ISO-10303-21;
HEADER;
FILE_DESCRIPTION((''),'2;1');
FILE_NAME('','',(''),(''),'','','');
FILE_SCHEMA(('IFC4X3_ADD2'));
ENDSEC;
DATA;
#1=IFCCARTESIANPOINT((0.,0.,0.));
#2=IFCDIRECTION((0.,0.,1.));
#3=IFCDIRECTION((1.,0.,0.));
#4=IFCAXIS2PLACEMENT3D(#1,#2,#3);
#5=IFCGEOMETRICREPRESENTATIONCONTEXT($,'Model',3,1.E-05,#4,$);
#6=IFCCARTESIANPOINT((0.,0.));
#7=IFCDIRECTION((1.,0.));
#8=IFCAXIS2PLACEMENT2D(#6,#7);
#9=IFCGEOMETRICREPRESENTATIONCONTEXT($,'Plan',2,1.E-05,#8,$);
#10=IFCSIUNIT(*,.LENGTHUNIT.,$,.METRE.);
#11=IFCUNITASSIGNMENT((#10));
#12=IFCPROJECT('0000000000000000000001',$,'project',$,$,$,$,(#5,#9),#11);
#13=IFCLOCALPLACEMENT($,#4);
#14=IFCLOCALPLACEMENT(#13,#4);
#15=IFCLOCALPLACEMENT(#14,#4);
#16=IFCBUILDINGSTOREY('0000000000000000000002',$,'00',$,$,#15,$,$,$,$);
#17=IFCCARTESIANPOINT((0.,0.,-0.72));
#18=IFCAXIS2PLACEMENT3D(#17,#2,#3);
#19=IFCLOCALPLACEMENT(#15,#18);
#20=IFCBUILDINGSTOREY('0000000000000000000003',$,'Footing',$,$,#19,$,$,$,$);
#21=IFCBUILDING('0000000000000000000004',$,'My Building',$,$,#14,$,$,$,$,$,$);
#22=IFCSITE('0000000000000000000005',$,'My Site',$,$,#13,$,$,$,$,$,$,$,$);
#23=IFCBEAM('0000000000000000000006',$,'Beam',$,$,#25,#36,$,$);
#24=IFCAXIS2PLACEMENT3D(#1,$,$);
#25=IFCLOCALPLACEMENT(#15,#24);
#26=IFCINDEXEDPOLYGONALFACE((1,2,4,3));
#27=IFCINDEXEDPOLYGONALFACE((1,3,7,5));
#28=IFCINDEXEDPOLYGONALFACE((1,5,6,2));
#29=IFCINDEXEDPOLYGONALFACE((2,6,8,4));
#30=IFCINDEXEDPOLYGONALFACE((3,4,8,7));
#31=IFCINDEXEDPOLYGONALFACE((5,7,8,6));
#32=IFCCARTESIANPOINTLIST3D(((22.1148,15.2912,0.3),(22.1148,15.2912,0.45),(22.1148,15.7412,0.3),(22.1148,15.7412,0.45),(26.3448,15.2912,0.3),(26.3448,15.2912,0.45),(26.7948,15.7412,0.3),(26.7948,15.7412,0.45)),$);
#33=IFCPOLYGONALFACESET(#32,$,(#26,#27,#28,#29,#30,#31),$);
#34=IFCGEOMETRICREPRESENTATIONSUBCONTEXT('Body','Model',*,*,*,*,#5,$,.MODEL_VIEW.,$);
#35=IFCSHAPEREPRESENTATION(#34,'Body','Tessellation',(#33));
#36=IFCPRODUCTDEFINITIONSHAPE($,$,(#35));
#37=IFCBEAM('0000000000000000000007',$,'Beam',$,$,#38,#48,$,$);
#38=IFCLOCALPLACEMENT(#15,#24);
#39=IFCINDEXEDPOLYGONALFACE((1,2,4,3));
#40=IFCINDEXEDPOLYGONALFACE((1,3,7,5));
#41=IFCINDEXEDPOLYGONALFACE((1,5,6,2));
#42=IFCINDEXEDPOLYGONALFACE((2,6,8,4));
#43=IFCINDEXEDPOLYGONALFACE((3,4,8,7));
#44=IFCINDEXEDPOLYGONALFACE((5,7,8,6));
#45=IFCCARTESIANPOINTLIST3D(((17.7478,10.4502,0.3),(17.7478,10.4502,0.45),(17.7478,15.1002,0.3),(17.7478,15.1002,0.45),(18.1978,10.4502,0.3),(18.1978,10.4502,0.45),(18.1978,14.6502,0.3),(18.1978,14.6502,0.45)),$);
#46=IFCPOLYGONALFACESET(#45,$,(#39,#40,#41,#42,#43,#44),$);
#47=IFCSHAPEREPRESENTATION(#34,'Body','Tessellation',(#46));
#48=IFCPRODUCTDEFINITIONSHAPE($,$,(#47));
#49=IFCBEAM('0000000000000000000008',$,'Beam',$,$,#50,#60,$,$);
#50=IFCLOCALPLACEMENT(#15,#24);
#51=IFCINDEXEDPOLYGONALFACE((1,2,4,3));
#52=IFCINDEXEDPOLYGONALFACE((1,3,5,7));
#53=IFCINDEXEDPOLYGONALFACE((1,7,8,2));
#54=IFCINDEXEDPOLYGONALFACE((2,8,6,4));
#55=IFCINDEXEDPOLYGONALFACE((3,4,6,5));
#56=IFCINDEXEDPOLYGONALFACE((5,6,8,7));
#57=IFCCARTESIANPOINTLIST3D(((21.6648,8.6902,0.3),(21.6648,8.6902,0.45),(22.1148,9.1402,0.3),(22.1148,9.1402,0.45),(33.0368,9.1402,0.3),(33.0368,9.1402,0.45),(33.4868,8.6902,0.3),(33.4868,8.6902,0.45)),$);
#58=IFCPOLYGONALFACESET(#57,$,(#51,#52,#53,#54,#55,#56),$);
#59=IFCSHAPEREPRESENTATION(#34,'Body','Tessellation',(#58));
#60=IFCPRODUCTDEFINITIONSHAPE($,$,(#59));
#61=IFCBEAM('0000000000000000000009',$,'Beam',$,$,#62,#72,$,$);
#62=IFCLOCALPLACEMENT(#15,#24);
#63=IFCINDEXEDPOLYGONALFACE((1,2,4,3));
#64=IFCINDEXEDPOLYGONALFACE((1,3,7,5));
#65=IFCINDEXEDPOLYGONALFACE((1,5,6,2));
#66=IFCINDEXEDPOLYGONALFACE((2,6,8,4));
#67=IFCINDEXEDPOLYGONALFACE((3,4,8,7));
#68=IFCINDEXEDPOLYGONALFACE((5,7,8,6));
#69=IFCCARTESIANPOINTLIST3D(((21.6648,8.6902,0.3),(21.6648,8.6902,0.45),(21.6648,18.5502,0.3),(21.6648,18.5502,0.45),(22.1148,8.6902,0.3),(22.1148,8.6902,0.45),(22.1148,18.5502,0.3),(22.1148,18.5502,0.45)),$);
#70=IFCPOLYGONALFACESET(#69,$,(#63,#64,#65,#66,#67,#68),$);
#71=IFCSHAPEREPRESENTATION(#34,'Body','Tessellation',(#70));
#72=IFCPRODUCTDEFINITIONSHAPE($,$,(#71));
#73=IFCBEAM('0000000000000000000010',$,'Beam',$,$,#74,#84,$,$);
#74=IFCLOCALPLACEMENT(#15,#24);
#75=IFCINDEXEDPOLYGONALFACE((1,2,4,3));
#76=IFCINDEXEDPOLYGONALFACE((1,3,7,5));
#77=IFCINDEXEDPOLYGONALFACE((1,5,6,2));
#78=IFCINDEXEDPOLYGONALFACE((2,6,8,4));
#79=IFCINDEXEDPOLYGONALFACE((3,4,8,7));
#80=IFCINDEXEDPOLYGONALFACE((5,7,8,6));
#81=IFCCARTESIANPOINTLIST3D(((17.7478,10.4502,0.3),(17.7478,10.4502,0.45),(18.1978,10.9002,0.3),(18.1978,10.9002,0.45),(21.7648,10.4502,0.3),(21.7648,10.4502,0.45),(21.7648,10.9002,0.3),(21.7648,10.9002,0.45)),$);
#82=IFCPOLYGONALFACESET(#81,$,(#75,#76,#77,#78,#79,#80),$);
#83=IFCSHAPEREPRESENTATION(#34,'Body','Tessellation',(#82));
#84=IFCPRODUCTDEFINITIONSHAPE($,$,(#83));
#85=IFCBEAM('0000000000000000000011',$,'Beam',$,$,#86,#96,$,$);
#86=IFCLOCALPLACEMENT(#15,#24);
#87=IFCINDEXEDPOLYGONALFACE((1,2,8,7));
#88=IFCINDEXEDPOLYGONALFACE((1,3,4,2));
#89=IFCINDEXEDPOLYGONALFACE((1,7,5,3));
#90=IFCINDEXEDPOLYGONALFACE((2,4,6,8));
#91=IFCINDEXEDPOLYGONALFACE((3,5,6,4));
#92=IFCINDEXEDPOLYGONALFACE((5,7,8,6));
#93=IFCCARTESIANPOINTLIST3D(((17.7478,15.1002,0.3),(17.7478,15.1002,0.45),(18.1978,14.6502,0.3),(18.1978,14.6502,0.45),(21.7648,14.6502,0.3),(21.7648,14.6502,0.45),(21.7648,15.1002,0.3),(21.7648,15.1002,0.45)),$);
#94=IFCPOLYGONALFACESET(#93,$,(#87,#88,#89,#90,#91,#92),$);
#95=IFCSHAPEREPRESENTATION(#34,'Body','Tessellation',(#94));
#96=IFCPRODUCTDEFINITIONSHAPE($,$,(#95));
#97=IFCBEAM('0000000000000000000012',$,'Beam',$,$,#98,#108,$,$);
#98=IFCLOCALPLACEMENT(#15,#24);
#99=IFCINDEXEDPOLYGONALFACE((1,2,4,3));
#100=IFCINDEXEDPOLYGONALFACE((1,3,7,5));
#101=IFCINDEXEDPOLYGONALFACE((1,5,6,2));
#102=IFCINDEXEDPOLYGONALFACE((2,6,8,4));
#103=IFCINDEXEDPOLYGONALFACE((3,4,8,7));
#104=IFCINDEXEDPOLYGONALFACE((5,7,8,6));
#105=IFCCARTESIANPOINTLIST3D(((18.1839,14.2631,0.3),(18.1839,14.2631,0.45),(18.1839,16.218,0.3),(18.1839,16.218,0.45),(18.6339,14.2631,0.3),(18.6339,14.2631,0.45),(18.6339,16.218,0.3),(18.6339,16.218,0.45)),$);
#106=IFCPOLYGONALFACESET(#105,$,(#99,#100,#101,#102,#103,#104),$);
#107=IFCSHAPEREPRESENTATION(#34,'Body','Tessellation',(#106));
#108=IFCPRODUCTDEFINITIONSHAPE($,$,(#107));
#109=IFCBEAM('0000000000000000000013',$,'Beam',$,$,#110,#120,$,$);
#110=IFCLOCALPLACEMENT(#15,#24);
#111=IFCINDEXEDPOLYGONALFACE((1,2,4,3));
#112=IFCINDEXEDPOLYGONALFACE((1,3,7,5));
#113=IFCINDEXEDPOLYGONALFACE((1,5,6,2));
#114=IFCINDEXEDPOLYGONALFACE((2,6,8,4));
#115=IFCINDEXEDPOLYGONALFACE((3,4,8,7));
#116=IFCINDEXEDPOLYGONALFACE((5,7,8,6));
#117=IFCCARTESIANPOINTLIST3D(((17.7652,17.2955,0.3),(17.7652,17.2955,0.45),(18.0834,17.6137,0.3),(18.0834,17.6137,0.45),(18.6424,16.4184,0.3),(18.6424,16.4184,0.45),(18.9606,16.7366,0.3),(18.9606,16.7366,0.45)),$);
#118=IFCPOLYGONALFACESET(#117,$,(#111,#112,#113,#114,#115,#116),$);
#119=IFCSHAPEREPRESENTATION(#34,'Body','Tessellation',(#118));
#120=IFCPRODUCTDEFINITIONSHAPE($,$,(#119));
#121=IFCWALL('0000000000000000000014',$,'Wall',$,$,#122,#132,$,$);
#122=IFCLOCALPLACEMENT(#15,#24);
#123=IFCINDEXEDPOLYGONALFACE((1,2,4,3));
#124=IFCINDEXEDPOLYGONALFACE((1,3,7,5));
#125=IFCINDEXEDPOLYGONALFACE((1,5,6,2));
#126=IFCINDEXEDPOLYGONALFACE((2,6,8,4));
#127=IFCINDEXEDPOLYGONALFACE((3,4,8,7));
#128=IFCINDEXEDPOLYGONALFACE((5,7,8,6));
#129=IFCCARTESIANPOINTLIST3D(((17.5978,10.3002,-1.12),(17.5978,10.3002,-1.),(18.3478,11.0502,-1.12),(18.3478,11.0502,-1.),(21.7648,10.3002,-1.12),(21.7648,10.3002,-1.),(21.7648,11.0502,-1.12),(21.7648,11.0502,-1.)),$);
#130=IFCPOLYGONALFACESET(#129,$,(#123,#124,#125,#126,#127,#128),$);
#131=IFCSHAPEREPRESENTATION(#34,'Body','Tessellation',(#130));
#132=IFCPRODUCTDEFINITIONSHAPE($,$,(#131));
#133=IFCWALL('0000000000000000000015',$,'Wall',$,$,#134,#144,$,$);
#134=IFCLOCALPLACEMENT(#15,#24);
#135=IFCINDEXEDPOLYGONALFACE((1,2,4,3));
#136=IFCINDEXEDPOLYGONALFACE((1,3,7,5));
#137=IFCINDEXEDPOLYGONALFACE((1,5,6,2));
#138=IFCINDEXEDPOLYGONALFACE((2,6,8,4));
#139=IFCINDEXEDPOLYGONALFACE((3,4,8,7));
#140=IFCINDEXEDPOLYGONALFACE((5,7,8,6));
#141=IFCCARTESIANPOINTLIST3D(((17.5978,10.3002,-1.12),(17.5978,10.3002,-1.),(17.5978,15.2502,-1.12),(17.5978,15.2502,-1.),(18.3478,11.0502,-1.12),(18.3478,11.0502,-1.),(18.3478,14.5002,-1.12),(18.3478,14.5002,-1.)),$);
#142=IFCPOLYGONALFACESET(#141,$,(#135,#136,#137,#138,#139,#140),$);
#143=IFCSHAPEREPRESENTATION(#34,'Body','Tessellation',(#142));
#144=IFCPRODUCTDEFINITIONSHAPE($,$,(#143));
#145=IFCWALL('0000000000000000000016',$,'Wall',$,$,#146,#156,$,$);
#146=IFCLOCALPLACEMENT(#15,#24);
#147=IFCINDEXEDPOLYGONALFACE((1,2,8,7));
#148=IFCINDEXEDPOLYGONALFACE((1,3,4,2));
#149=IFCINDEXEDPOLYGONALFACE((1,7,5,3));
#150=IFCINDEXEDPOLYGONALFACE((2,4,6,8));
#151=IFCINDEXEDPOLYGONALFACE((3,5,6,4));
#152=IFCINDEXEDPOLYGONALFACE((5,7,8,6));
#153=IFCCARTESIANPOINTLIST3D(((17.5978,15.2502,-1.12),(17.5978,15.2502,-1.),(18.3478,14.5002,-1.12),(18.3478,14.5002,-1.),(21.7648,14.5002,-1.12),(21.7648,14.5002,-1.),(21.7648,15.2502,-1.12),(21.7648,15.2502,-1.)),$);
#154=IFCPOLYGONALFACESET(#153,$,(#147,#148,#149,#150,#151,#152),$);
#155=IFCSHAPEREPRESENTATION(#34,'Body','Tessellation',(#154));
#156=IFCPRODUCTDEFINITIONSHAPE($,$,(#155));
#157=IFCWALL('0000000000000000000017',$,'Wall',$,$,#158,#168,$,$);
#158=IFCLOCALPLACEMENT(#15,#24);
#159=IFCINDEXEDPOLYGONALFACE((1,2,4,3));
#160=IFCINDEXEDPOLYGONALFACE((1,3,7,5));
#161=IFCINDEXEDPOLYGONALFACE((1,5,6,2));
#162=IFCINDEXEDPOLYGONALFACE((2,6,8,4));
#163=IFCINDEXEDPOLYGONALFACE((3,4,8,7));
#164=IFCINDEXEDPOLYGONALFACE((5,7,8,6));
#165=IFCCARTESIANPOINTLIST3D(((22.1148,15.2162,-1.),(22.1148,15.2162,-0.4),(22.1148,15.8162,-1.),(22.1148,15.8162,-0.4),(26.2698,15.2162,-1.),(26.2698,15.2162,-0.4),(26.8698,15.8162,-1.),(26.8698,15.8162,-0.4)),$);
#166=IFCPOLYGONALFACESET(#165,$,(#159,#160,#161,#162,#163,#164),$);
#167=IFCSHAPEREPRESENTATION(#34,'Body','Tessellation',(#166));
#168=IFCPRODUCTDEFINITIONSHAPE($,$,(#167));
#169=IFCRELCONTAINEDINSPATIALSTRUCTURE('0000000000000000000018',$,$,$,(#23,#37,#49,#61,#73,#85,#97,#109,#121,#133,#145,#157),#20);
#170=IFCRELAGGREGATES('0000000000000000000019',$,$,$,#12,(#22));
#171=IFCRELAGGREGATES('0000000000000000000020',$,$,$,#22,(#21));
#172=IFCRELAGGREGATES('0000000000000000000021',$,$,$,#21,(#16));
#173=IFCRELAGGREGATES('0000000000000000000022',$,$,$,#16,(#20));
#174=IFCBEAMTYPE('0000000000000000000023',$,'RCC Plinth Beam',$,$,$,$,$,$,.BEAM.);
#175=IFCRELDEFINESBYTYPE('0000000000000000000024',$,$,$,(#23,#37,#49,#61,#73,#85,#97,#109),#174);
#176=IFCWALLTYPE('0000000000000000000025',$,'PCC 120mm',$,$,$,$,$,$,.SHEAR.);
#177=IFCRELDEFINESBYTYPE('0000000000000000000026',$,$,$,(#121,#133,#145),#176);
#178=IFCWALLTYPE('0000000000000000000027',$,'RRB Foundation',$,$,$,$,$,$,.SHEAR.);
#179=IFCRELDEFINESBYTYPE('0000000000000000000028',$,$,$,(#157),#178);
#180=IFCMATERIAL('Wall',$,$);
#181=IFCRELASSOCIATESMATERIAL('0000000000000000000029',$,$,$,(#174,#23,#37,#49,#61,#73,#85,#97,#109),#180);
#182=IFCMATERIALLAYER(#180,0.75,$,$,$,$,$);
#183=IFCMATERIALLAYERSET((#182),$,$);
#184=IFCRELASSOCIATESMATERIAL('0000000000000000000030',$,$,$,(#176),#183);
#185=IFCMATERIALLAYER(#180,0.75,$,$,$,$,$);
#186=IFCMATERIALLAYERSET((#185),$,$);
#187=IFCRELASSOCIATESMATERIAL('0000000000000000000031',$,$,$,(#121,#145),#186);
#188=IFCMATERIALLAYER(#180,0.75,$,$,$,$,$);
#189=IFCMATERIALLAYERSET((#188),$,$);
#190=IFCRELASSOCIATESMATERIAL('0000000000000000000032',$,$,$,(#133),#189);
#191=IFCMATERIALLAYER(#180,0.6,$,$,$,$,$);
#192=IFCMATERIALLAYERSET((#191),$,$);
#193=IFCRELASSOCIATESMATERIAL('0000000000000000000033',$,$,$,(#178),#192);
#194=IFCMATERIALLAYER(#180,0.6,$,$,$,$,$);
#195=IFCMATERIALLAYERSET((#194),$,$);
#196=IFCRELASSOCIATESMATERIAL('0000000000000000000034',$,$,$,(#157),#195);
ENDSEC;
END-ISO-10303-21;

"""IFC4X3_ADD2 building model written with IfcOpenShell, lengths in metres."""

from ifc_helpers import new_model, si_unit, frame, origin_with_axes, origin_2d_with_axis, place, context, subcontext, project, spatial, line, indexed_curve, rectangle, outline, extrude, clip, halfspace, material, layer, layer_set, layer_usage, material_profile, profile_set, profile_usage, type_object, element, save


model = new_model("IFC4X3_ADD2")

# Units and contexts
model_context = context("Model", 3, precision=1e-05, world=origin_with_axes())
plan_context = context("Plan", 2, precision=1e-05, world=origin_2d_with_axis())
body_context = subcontext(model_context, "Body", "Model", "MODEL_VIEW")
ifc_project = project(units=[si_unit("LENGTHUNIT", "METRE")], contexts=[model_context, plan_context])

# Site, building, storeys
site_placement = place(None, origin_with_axes())
site = spatial("IfcSite", under=ifc_project, at=site_placement, Name="My Site")
building_placement = place(site_placement, origin_with_axes())
building = spatial("IfcBuilding", under=site, at=building_placement, Name="My Building")
storey_1_placement = place(building_placement, origin_with_axes())
storey_1 = spatial("IfcBuildingStorey", under=building, at=storey_1_placement, Name="00")
storey_2_placement = place(storey_1_placement, frame((0.0, 0.0, -0.72), z_axis=(0.0, 0.0, 1.0), x_axis=(1.0, 0.0, 0.0)))
storey_2 = spatial("IfcBuildingStorey", under=storey_1, at=storey_2_placement, Name="Footing")

# Beams
ifc_material_1 = material(Name="Wall")
ifc_material_profile_1 = material_profile(ifc_material_1, rectangle(XDim=0.45, YDim=0.15))
ifc_profile_set_1 = profile_set([ifc_material_profile_1])
ifc_profile_usage_1 = profile_usage(ifc_profile_set_1, cardinal=5)
ifc_material_profile_2 = material_profile(ifc_material_1, rectangle(XDim=0.45, YDim=0.15))
ifc_profile_set_2 = profile_set([ifc_material_profile_2])
beam_type = type_object("IfcBeamType", Name="RCC Plinth Beam", PredefinedType="BEAM", material=ifc_profile_set_2)
beam_1_placement = place(storey_2_placement, frame((22.1148, 15.5162, 1.095), z_axis=(1.0, 0.0, 0.0), x_axis=(0.0, 1.0, 0.0)))
element("IfcBeam", 1, at=beam_1_placement, inside=storey_2, type_object=beam_type, material=ifc_profile_usage_1, Name="Beam", context=body_context, shape_type="Clipping", body=[
    clip(extrude(rectangle(XDim=0.45, YDim=0.15), origin_with_axes(), (0.0, 0.0, 1.0), 4.68), halfspace(frame((0.225, -0.375, 4.68), z_axis=(-0.707107, 0.0, 0.707107), x_axis=(0.0, 1.0, 0.0)), False)),
])
ifc_material_profile_3 = material_profile(ifc_material_1, rectangle(XDim=0.45, YDim=0.15))
ifc_profile_set_3 = profile_set([ifc_material_profile_3])
ifc_profile_usage_2 = profile_usage(ifc_profile_set_3, cardinal=5)
beam_2_placement = place(storey_2_placement, frame((17.9728, 10.4502, 1.095), z_axis=(0.0, 1.0, 0.0), x_axis=(-1.0, 0.0, 0.0)))
element("IfcBeam", 2, at=beam_2_placement, inside=storey_2, type_object=beam_type, material=ifc_profile_usage_2, Name="Beam", context=body_context, shape_type="Clipping", body=[
    clip(extrude(rectangle(XDim=0.45, YDim=0.15), origin_with_axes(), (0.0, 0.0, 1.0), 4.65), halfspace(frame((0.225, -0.375, 4.65), z_axis=(-0.707107, 0.0, 0.707107), x_axis=(0.0, 1.0, 0.0)), False)),
])
ifc_material_profile_4 = material_profile(ifc_material_1, rectangle(XDim=0.45, YDim=0.15))
ifc_profile_set_4 = profile_set([ifc_material_profile_4])
ifc_profile_usage_3 = profile_usage(ifc_profile_set_4, cardinal=5)
beam_3_placement = place(storey_2_placement, frame((21.6648, 8.9152, 1.095), z_axis=(1.0, 0.0, 0.0), x_axis=(0.0, 1.0, 0.0)))
element("IfcBeam", 3, at=beam_3_placement, inside=storey_2, type_object=beam_type, material=ifc_profile_usage_3, Name="Beam", context=body_context, shape_type="Clipping", body=[
    clip(clip(extrude(rectangle(XDim=0.45, YDim=0.15), origin_with_axes(), (0.0, 0.0, 1.0), 11.822), halfspace(frame((-0.225, -0.375, 11.822), z_axis=(0.707104, 0.0, 0.70711), x_axis=(0.0, -1.0, 0.0)), False)), halfspace(frame((-0.225, -0.375, 0.0), z_axis=(0.707107, 0.0, -0.707107), x_axis=(0.0, -1.0, 0.0)), False)),
])
ifc_material_profile_5 = material_profile(ifc_material_1, rectangle(XDim=0.45, YDim=0.15))
ifc_profile_set_5 = profile_set([ifc_material_profile_5])
ifc_profile_usage_4 = profile_usage(ifc_profile_set_5, cardinal=5)
beam_4_placement = place(storey_2_placement, frame((21.8898, 8.6902, 1.095), z_axis=(0.0, 1.0, 0.0), x_axis=(-1.0, 0.0, 0.0)))
element("IfcBeam", 4, at=beam_4_placement, inside=storey_2, type_object=beam_type, material=ifc_profile_usage_4, Name="Beam", context=body_context, shape_type="SweptSolid", body=[
    extrude(rectangle(XDim=0.45, YDim=0.15), origin_with_axes(), (0.0, 0.0, 1.0), 9.86),
])
ifc_material_profile_6 = material_profile(ifc_material_1, rectangle(XDim=0.45, YDim=0.15))
ifc_profile_set_6 = profile_set([ifc_material_profile_6])
ifc_profile_usage_5 = profile_usage(ifc_profile_set_6, cardinal=5)
beam_5_placement = place(storey_2_placement, frame((17.7478, 10.6752, 1.095), z_axis=(1.0, 0.0, 0.0), x_axis=(0.0, 1.0, 0.0)))
element("IfcBeam", 5, at=beam_5_placement, inside=storey_2, type_object=beam_type, material=ifc_profile_usage_5, Name="Beam", context=body_context, shape_type="Clipping", body=[
    clip(extrude(rectangle(XDim=0.45, YDim=0.15), origin_with_axes(), (0.0, 0.0, 1.0), 4.017), halfspace(frame((-0.225, -0.375, 0.0), z_axis=(0.707107, 0.0, -0.707107), x_axis=(0.0, -1.0, 0.0)), False)),
])
ifc_profile_usage_6 = profile_usage(ifc_profile_set_6, cardinal=5)
beam_6_placement = place(storey_2_placement, frame((17.7478, 14.8752, 1.095), z_axis=(1.0, 0.0, 0.0), x_axis=(0.0, 1.0, 0.0)))
element("IfcBeam", 6, at=beam_6_placement, inside=storey_2, type_object=beam_type, material=ifc_profile_usage_6, Name="Beam", context=body_context, shape_type="Clipping", body=[
    clip(extrude(rectangle(XDim=0.45, YDim=0.15), origin_with_axes(), (0.0, 0.0, 1.0), 4.017), halfspace(frame((0.225, -0.375, 0.0), z_axis=(-0.707107, 0.0, -0.707107), x_axis=(0.0, 1.0, 0.0)), False)),
])
ifc_profile_usage_7 = profile_usage(ifc_profile_set_3, cardinal=5)
beam_7_placement = place(storey_2_placement, frame((18.4089, 14.2631, 1.095), z_axis=(0.0, 1.0, 0.0), x_axis=(-1.0, 0.0, 0.0)))
element("IfcBeam", 7, at=beam_7_placement, inside=storey_2, type_object=beam_type, material=ifc_profile_usage_7, Name="Beam", context=body_context, shape_type="SweptSolid", body=[
    extrude(rectangle(XDim=0.45, YDim=0.15), origin_with_axes(), (0.0, 0.0, 1.0), 1.955),
])
ifc_profile_usage_8 = profile_usage(ifc_profile_set_3, cardinal=5)
beam_8_placement = place(storey_2_placement, frame((18.8015, 16.5775, 1.095), z_axis=(-0.707107, 0.707107, 0.0), x_axis=(-0.707107, -0.707107, 0.0)))
element("IfcBeam", 8, at=beam_8_placement, inside=storey_2, type_object=beam_type, material=ifc_profile_usage_8, Name="Beam", context=body_context, shape_type="SweptSolid", body=[
    extrude(rectangle(XDim=0.45, YDim=0.15), origin_with_axes(), (0.0, 0.0, 1.0), 1.2405),
])

# Walls
ifc_layer_1 = layer(ifc_material_1, 0.75)
ifc_layer_set_1 = layer_set([ifc_layer_1])
ifc_layer_usage_1 = layer_usage(ifc_layer_set_1, "AXIS2", "POSITIVE", 0.0)
ifc_layer_2 = layer(ifc_material_1, 0.75)
ifc_layer_set_2 = layer_set([ifc_layer_2])
wall_type_1 = type_object("IfcWallType", Name="PCC 120mm", PredefinedType="SHEAR", material=ifc_layer_set_2)
wall_1_placement = place(storey_2_placement, frame((18.3478, 10.3002, -0.4), z_axis=(0.0, 0.0, 1.0), x_axis=(1.0, 0.0, 0.0)))
element("IfcWall", 9, at=wall_1_placement, inside=storey_2, type_object=wall_type_1, material=ifc_layer_usage_1, Name="Wall", context=body_context, shape_type="SweptSolid", body=[
    extrude(outline(indexed_curve([(-0.75, 0.0), (0.0, 0.75), (3.417, 0.75), (3.417, 0.0)], segments=[line(1, 2, 3, 4, 1)])), origin_with_axes(), (0.0, 0.0, 1.0), 0.12),
])
ifc_layer_3 = layer(ifc_material_1, 0.75)
ifc_layer_set_3 = layer_set([ifc_layer_3])
ifc_layer_usage_2 = layer_usage(ifc_layer_set_3, "AXIS2", "POSITIVE", 0.0)
wall_2_placement = place(storey_2_placement, frame((18.3478, 10.3002, -0.4), z_axis=(0.0, 0.0, 1.0), x_axis=(0.0, 1.0, 0.0)))
element("IfcWall", 10, at=wall_2_placement, inside=storey_2, type_object=wall_type_1, material=ifc_layer_usage_2, Name="Wall", context=body_context, shape_type="SweptSolid", body=[
    extrude(outline(indexed_curve([(0.75, 0.0), (0.0, 0.75), (4.95, 0.75), (4.2, 0.0)], segments=[line(1, 2, 3, 4, 1)])), origin_with_axes(), (0.0, 0.0, 1.0), 0.12),
])
ifc_layer_usage_3 = layer_usage(ifc_layer_set_1, "AXIS2", "POSITIVE", 0.0)
wall_3_placement = place(storey_2_placement, frame((18.3478, 14.5002, -0.4), z_axis=(0.0, 0.0, 1.0), x_axis=(1.0, 0.0, 0.0)))
element("IfcWall", 11, at=wall_3_placement, inside=storey_2, type_object=wall_type_1, material=ifc_layer_usage_3, Name="Wall", context=body_context, shape_type="SweptSolid", body=[
    extrude(outline(indexed_curve([(0.0, 0.0), (-0.75, 0.75), (3.417, 0.75), (3.417, 0.0)], segments=[line(1, 2, 3, 4, 1)])), origin_with_axes(), (0.0, 0.0, 1.0), 0.12),
])
ifc_layer_4 = layer(ifc_material_1, 0.6)
ifc_layer_set_4 = layer_set([ifc_layer_4])
ifc_layer_usage_4 = layer_usage(ifc_layer_set_4, "AXIS2", "POSITIVE", 0.0)
ifc_layer_5 = layer(ifc_material_1, 0.6)
ifc_layer_set_5 = layer_set([ifc_layer_5])
wall_type_2 = type_object("IfcWallType", Name="RRB Foundation", PredefinedType="SHEAR", material=ifc_layer_set_5)
wall_4_placement = place(storey_2_placement, frame((22.1148, 15.2162, -0.28), z_axis=(0.0, 0.0, 1.0), x_axis=(1.0, 0.0, 0.0)))
element("IfcWall", 12, at=wall_4_placement, inside=storey_2, type_object=wall_type_2, material=ifc_layer_usage_4, Name="Wall", context=body_context, shape_type="SweptSolid", body=[
    extrude(outline(indexed_curve([(0.0, 0.0), (0.0, 0.6), (4.755, 0.6), (4.155, 0.0)], segments=[line(1, 2, 3, 4, 1)])), origin_with_axes(), (0.0, 0.0, 1.0), 0.6),
])

save(model, "model.ifc")
